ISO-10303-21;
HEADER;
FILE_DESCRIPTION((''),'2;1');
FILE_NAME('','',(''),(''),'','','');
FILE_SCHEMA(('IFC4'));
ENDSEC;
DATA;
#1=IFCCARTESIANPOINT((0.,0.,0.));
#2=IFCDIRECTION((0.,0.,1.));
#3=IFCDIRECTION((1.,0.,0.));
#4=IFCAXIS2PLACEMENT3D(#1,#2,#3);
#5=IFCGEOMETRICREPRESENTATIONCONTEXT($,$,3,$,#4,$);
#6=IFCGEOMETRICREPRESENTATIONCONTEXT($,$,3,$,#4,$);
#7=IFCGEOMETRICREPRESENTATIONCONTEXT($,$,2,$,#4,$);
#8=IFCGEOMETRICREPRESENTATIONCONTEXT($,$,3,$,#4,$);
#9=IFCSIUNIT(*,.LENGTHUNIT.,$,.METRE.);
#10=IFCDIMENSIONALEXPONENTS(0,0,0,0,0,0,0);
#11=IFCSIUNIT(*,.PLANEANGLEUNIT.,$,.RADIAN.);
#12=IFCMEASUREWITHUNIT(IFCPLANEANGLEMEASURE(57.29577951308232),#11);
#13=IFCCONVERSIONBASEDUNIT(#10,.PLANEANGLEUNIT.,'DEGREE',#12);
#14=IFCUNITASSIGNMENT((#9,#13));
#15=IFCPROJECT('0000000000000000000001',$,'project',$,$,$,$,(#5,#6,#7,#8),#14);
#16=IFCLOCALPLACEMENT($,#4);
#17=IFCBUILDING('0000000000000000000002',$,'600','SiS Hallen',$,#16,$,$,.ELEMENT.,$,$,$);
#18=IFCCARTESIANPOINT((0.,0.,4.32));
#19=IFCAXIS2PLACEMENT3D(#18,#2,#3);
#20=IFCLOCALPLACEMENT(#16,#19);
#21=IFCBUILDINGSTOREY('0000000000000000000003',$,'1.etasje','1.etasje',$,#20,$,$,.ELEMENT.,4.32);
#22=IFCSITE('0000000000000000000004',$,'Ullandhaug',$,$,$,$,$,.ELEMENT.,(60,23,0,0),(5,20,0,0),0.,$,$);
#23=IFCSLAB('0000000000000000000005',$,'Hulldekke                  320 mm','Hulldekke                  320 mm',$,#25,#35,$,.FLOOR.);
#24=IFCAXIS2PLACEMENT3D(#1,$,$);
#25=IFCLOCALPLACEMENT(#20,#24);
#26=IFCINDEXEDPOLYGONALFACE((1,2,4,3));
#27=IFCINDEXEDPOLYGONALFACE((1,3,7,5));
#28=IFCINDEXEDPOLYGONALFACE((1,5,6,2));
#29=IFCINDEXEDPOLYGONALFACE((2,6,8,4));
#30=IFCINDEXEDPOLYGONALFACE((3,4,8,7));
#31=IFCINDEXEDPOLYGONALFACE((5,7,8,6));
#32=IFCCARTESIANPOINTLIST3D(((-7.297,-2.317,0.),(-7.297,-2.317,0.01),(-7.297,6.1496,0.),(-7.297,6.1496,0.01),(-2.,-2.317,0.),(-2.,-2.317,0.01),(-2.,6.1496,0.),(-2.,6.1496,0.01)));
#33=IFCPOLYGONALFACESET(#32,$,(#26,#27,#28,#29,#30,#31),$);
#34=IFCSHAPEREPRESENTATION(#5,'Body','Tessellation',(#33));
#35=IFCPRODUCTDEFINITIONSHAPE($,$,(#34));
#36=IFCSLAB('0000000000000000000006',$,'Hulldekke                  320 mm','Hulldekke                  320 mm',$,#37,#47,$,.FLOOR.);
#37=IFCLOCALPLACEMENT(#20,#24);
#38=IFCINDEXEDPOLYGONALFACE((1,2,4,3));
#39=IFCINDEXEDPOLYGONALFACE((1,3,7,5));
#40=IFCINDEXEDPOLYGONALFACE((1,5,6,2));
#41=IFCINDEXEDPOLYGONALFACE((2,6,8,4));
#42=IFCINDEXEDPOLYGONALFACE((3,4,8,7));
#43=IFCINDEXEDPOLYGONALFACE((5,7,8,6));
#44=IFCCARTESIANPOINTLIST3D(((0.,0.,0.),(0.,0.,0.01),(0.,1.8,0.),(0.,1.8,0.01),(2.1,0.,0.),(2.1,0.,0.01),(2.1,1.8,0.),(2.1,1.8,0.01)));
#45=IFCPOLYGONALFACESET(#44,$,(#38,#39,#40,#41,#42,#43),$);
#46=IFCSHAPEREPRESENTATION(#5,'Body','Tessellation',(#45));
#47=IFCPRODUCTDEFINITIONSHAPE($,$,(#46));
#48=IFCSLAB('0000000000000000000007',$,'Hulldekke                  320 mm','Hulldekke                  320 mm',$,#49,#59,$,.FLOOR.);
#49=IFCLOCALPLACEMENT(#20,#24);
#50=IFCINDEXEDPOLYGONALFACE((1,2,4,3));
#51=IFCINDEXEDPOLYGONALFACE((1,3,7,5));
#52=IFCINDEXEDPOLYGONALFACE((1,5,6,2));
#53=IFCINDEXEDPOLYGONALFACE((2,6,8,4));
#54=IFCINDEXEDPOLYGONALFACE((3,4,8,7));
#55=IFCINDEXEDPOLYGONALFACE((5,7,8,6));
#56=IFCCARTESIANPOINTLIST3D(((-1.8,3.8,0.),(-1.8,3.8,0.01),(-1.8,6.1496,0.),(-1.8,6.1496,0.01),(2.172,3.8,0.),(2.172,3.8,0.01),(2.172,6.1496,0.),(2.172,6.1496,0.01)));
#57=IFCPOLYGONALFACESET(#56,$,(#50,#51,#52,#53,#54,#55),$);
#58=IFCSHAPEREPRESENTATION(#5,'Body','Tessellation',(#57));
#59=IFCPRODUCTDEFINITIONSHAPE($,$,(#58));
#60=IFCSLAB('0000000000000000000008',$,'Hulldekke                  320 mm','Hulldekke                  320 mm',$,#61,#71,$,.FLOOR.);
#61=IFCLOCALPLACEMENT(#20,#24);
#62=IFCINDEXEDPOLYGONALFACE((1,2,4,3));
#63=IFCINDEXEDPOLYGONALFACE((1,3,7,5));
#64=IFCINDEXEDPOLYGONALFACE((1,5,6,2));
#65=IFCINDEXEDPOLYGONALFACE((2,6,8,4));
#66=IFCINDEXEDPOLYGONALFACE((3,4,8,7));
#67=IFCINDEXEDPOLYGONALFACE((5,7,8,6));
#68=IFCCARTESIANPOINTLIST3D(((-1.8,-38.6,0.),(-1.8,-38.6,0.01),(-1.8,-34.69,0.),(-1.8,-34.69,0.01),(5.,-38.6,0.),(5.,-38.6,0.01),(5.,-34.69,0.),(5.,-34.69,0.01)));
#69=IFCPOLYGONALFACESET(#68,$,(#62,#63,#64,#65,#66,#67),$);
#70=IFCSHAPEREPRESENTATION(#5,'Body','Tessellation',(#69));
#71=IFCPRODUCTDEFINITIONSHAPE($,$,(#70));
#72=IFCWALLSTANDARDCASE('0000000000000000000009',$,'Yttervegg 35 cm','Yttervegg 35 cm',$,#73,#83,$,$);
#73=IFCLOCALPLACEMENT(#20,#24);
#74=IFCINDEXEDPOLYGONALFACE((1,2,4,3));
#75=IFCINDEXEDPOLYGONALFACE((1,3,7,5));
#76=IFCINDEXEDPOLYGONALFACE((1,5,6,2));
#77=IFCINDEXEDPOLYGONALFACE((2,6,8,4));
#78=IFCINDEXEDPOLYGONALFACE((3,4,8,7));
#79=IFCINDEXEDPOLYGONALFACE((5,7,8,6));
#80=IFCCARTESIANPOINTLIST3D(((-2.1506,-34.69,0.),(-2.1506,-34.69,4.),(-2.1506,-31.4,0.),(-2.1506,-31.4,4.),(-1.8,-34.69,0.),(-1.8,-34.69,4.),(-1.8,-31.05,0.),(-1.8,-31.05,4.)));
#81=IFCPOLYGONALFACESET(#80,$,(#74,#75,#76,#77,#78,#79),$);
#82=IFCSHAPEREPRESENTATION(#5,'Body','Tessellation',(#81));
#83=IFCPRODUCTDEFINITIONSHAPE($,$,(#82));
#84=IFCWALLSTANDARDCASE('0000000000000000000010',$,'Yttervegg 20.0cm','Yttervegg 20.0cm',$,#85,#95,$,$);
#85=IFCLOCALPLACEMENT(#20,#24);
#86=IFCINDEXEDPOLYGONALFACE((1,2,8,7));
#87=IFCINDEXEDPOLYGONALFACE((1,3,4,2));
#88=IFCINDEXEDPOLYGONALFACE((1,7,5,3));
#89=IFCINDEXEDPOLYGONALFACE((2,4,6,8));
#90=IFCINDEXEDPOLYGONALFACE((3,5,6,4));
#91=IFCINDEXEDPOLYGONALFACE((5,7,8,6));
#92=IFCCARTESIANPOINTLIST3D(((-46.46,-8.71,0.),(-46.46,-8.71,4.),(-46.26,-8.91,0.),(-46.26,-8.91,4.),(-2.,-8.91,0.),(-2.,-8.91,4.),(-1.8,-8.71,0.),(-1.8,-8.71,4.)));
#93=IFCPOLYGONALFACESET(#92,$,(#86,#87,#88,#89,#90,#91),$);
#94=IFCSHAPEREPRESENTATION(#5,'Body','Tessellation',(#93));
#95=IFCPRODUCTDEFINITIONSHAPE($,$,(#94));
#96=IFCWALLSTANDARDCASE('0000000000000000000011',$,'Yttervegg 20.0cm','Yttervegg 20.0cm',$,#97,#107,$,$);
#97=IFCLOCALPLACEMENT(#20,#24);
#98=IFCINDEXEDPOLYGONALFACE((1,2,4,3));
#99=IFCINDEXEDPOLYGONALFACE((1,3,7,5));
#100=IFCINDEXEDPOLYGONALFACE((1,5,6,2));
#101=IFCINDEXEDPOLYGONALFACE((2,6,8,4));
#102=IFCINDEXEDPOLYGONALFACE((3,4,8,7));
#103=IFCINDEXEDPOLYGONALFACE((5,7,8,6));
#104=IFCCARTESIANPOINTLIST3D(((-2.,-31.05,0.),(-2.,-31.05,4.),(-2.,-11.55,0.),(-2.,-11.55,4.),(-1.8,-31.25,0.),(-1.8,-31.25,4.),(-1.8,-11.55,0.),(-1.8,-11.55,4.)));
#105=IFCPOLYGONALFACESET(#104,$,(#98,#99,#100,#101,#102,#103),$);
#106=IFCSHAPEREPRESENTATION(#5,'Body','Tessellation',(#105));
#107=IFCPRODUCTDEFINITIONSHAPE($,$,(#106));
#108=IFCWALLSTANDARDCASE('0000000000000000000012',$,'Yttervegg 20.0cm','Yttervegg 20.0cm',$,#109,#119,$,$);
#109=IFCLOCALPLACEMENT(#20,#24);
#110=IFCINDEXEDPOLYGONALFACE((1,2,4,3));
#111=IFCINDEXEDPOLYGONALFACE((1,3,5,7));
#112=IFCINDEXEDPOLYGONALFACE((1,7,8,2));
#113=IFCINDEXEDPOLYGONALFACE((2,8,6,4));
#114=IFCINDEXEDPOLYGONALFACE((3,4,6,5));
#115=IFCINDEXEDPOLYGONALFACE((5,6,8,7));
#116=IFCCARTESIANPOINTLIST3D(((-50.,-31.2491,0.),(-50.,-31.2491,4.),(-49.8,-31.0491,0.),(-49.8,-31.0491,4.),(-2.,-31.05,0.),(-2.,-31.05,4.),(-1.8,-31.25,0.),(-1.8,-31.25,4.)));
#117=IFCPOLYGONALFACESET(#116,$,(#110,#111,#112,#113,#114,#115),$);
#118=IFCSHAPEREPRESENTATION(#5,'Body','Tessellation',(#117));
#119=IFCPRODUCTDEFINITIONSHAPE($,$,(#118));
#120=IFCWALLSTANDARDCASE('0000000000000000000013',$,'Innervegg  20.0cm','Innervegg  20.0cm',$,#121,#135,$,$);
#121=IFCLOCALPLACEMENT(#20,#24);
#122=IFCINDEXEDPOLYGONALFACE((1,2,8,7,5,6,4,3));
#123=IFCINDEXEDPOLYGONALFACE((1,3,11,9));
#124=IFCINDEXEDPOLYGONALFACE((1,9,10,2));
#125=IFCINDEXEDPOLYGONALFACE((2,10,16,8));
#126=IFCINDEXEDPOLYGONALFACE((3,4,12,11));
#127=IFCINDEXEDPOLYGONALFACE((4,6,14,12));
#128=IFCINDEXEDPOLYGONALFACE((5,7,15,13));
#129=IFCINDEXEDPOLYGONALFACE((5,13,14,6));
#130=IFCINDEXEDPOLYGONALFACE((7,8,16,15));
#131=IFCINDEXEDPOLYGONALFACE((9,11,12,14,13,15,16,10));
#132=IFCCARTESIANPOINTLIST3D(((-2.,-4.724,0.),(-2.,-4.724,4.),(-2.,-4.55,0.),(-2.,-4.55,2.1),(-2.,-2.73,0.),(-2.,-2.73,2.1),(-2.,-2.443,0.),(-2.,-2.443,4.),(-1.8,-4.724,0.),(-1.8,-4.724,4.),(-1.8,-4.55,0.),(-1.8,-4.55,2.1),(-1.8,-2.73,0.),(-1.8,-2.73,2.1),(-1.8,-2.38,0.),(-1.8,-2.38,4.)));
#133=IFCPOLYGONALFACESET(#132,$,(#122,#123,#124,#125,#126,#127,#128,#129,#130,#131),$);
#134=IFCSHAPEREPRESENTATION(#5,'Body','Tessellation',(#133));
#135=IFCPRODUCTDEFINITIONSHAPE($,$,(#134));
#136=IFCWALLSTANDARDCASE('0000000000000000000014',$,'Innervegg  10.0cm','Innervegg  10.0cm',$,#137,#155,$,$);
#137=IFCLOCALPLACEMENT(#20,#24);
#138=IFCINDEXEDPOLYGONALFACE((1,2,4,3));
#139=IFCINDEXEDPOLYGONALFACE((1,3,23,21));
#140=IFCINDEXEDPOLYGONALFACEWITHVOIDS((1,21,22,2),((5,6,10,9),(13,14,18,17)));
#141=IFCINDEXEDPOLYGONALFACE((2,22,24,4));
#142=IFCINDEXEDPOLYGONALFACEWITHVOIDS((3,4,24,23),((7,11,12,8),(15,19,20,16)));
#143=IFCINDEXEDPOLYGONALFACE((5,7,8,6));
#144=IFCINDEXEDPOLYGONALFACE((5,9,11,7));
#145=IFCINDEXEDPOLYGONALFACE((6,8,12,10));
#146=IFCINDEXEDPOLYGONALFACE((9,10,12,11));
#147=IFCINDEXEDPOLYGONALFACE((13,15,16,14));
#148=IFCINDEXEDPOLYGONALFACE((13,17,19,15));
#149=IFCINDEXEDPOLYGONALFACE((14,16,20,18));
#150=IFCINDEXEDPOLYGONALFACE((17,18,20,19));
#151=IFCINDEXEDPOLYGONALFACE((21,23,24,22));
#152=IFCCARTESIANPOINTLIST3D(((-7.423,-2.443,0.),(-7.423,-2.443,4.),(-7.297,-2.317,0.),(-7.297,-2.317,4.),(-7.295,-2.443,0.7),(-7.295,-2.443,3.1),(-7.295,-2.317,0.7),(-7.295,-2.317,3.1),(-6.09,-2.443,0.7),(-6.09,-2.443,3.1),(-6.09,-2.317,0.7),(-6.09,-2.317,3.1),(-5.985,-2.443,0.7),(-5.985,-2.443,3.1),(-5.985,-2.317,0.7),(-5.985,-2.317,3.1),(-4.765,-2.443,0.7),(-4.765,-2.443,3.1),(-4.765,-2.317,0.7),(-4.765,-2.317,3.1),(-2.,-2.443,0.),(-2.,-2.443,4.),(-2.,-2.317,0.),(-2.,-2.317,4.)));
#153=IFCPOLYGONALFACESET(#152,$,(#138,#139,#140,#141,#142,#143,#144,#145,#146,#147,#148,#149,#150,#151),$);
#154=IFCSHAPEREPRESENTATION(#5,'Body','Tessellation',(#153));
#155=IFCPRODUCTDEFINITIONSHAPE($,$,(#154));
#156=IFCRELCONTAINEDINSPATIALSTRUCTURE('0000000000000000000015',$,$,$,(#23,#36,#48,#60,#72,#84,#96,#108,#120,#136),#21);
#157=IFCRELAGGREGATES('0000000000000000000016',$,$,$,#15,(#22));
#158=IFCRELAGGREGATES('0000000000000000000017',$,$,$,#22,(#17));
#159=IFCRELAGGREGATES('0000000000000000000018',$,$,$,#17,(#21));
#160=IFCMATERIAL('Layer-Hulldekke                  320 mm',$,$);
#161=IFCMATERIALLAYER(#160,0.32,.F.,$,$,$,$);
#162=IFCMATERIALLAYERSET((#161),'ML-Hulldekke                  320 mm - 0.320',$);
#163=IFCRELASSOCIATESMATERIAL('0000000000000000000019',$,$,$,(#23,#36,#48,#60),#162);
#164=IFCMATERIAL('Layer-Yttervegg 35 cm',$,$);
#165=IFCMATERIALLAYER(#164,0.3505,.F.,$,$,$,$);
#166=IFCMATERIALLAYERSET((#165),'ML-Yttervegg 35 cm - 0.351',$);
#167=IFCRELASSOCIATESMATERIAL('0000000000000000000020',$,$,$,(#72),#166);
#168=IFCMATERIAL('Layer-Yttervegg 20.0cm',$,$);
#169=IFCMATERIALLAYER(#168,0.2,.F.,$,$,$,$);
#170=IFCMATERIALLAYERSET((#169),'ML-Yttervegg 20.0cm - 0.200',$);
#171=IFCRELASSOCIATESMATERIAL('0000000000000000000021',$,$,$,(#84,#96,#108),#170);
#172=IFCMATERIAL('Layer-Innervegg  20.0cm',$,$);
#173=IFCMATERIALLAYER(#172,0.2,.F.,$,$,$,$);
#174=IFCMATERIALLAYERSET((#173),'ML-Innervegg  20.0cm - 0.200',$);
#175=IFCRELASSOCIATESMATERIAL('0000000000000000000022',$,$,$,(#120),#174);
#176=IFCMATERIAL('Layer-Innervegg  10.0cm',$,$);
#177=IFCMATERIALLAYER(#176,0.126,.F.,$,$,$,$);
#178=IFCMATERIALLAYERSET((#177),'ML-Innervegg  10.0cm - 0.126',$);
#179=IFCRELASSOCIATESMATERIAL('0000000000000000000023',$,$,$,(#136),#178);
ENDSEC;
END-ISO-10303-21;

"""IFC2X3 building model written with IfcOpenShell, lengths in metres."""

from ifc_helpers import new_model, entity, si_unit, converted_unit, frame, origin_with_axes, place, context, project, spatial, polyline, outline, extrude, material, layer, layer_set, layer_usage, element, save


model = new_model("IFC2X3")

# Units and contexts
context_of_model_1 = context(None, 3, world=origin_with_axes())
context_of_model_2 = context(None, 3, world=origin_with_axes())
context_of_model_3 = context(None, 2, world=origin_with_axes())
context_of_model_4 = context(None, 3, world=origin_with_axes())
ifc_project = project(units=[si_unit("LENGTHUNIT", "METRE"), converted_unit("PLANEANGLEUNIT", "DEGREE", entity("IfcPlaneAngleMeasure", 57.29577951308232), si_unit("PLANEANGLEUNIT", "RADIAN"), dimensions=[0, 0, 0, 0, 0, 0, 0])], contexts=[context_of_model_1, context_of_model_2, context_of_model_3, context_of_model_4])

# Site, building, storey
site = spatial("IfcSite", under=ifc_project, Name="Ullandhaug", CompositionType="ELEMENT", RefLatitude=(60, 23, 0, 0), RefLongitude=(5, 20, 0, 0), RefElevation=0.0)
building_placement = place(None, origin_with_axes())
building = spatial("IfcBuilding", under=site, at=building_placement, Name="600", Description="SiS Hallen", CompositionType="ELEMENT")
storey_placement = place(building_placement, frame((0.0, 0.0, 4.32), z_axis=(0.0, 0.0, 1.0), x_axis=(1.0, 0.0, 0.0)))
storey = spatial("IfcBuildingStorey", under=building, at=storey_placement, Name="1.etasje", Description="1.etasje", CompositionType="ELEMENT", Elevation=4.32)

# Slabs
ifc_material_1 = material(Name="Layer-Hulldekke                  320 mm")
ifc_layer_1 = layer(ifc_material_1, 0.32, ventilated=False)
ifc_layer_set_1 = layer_set([ifc_layer_1], Name="ML-Hulldekke                  320 mm - 0.320")
ifc_layer_usage_1 = layer_usage(ifc_layer_set_1, "AXIS2", "POSITIVE", 0.0)
slab_1_placement = place(storey_placement, frame((-7.297, -2.317, 0.0), z_axis=(0.0, 0.0, 1.0), x_axis=(1.0, 0.0, 0.0)))
element("IfcSlab", 1, at=slab_1_placement, inside=storey, material=ifc_layer_usage_1, Name="Hulldekke                  320 mm", Description="Hulldekke                  320 mm", PredefinedType="FLOOR", context=context_of_model_1, shape_type="SweptSolid", body=[
    extrude(outline(polyline([(0.0, 0.0), (5.297, 0.0), (5.297, 8.4666), (0.0, 8.4666), (0.0, 0.0)])), origin_with_axes(), (0.0, 0.0, 1.0), 0.01),
])
slab_2_placement = place(storey_placement, origin_with_axes())
element("IfcSlab", 2, at=slab_2_placement, inside=storey, material=ifc_layer_usage_1, Name="Hulldekke                  320 mm", Description="Hulldekke                  320 mm", PredefinedType="FLOOR", context=context_of_model_1, shape_type="SweptSolid", body=[
    extrude(outline(polyline([(0.0, 0.0), (2.1, 0.0), (2.1, 1.8), (0.0, 1.8), (0.0, 0.0)])), origin_with_axes(), (0.0, 0.0, 1.0), 0.01),
])
slab_3_placement = place(storey_placement, frame((-1.8, 3.8, 0.0), z_axis=(0.0, 0.0, 1.0), x_axis=(1.0, 0.0, 0.0)))
element("IfcSlab", 3, at=slab_3_placement, inside=storey, material=ifc_layer_usage_1, Name="Hulldekke                  320 mm", Description="Hulldekke                  320 mm", PredefinedType="FLOOR", context=context_of_model_1, shape_type="SweptSolid", body=[
    extrude(outline(polyline([(0.0, 0.0), (3.972, 0.0), (3.972, 2.3496), (0.0, 2.3496), (0.0, 0.0)])), origin_with_axes(), (0.0, 0.0, 1.0), 0.01),
])
slab_4_placement = place(storey_placement, frame((-1.8, -38.6, 0.0), z_axis=(0.0, 0.0, 1.0), x_axis=(1.0, 0.0, 0.0)))
element("IfcSlab", 4, at=slab_4_placement, inside=storey, material=ifc_layer_usage_1, Name="Hulldekke                  320 mm", Description="Hulldekke                  320 mm", PredefinedType="FLOOR", context=context_of_model_1, shape_type="SweptSolid", body=[
    extrude(outline(polyline([(0.0, 0.0), (6.8, 0.0), (6.8, 3.91), (0.0, 3.91), (0.0, 0.0)])), origin_with_axes(), (0.0, 0.0, 1.0), 0.01),
])

# Walls
ifc_material_2 = material(Name="Layer-Yttervegg 35 cm")
ifc_layer_2 = layer(ifc_material_2, 0.3505, ventilated=False)
ifc_layer_set_2 = layer_set([ifc_layer_2], Name="ML-Yttervegg 35 cm - 0.351")
ifc_layer_usage_2 = layer_usage(ifc_layer_set_2, "AXIS2", "POSITIVE", 0.0)
wall_1_placement = place(storey_placement, frame((-2.1506, -31.4, 0.0), z_axis=(0.0, 0.0, 1.0), x_axis=(0.0, -1.0, 0.0)))
element("IfcWallStandardCase", 5, at=wall_1_placement, inside=storey, material=ifc_layer_usage_2, Name="Yttervegg 35 cm", Description="Yttervegg 35 cm", context=context_of_model_1, shape_type="SweptSolid", body=[
    extrude(outline(polyline([(0.0, 0.0), (3.29, 0.0), (3.29, 0.3506), (-0.35, 0.3506), (0.0, 0.0)])), frame((0.0, 0.0, 0.0), z_axis=(0.0, 0.0, 1.0), x_axis=(1.0, 0.0, 0.0)), (0.0, 0.0, 1.0), 4.0),
])
ifc_material_3 = material(Name="Layer-Yttervegg 20.0cm")
ifc_layer_3 = layer(ifc_material_3, 0.2, ventilated=False)
ifc_layer_set_3 = layer_set([ifc_layer_3], Name="ML-Yttervegg 20.0cm - 0.200")
ifc_layer_usage_3 = layer_usage(ifc_layer_set_3, "AXIS2", "POSITIVE", 0.0)
wall_2_placement = place(storey_placement, frame((-46.26, -8.91, 0.0), z_axis=(0.0, 0.0, 1.0), x_axis=(1.0, 0.0, 0.0)))
element("IfcWallStandardCase", 6, at=wall_2_placement, inside=storey, material=ifc_layer_usage_3, Name="Yttervegg 20.0cm", Description="Yttervegg 20.0cm", context=context_of_model_1, shape_type="SweptSolid", body=[
    extrude(outline(polyline([(0.0, 0.0), (44.26, 0.0), (44.46, 0.2), (-0.2, 0.2), (0.0, 0.0)])), origin_with_axes(), (0.0, 0.0, 1.0), 4.0),
])
wall_3_placement = place(storey_placement, frame((-2.0, -11.55, 0.0), z_axis=(0.0, 0.0, 1.0), x_axis=(0.0, -1.0, 0.0)))
element("IfcWallStandardCase", 7, at=wall_3_placement, inside=storey, material=ifc_layer_usage_3, Name="Yttervegg 20.0cm", Description="Yttervegg 20.0cm", context=context_of_model_1, shape_type="SweptSolid", body=[
    extrude(outline(polyline([(0.0, 0.0), (19.5, 0.0), (19.7, 0.2), (0.0, 0.2), (0.0, 0.0)])), frame((0.0, 0.0, 0.0), z_axis=(0.0, 0.0, 1.0), x_axis=(1.0, 0.0, 0.0)), (0.0, 0.0, 1.0), 4.0),
])
wall_4_placement = place(storey_placement, frame((-2.0, -31.05, 0.0), z_axis=(0.0, 0.0, 1.0), x_axis=(-1.0, 0.000019, 0.0)))
element("IfcWallStandardCase", 8, at=wall_4_placement, inside=storey, material=ifc_layer_usage_3, Name="Yttervegg 20.0cm", Description="Yttervegg 20.0cm", context=context_of_model_1, shape_type="SweptSolid", body=[
    extrude(outline(polyline([(0.0, 0.0), (47.8, 0.0), (48.0, 0.2), (-0.2, 0.2), (0.0, 0.0)])), frame((0.0, 0.0, 0.0), z_axis=(0.0, 0.0, 1.0), x_axis=(1.0, 0.0, 0.0)), (0.0, 0.0, 1.0), 4.0),
])

# Wall, opening
ifc_material_4 = material(Name="Layer-Innervegg  20.0cm")
ifc_layer_4 = layer(ifc_material_4, 0.2, ventilated=False)
ifc_layer_set_4 = layer_set([ifc_layer_4], Name="ML-Innervegg  20.0cm - 0.200")
ifc_layer_usage_4 = layer_usage(ifc_layer_set_4, "AXIS2", "POSITIVE", 0.0)
wall_5_placement = place(storey_placement, frame((-1.8, -4.724, 0.0), z_axis=(0.0, 0.0, 1.0), x_axis=(0.0, 1.0, 0.0)))
wall_5 = element("IfcWallStandardCase", 9, at=wall_5_placement, inside=storey, material=ifc_layer_usage_4, Name="Innervegg  20.0cm", Description="Innervegg  20.0cm", context=context_of_model_1, shape_type="SweptSolid", body=[
    extrude(outline(polyline([(0.0, 0.0), (2.344, 0.0), (2.281, 0.2), (0.0, 0.2), (0.0, 0.0)])), frame((0.0, 0.0, 0.0), z_axis=(0.0, 0.0, 1.0), x_axis=(1.0, 0.0, 0.0)), (0.0, 0.0, 1.0), 4.0),
])
opening_1_placement = place(wall_5_placement, frame((0.174, 0.2, 0.0), z_axis=(0.0, 0.0, 1.0), x_axis=(1.0, 0.0, 0.0)))
element("IfcOpeningElement", 10, at=opening_1_placement, cuts=wall_5, context=context_of_model_1, shape_type="SweptSolid", body=[
    extrude(outline(polyline([(0.0, 0.0), (2.1, 0.0), (2.1, 1.82), (0.0, 1.82), (0.0, 0.0)])), frame((0.0, 0.0, 0.0), z_axis=(0.0, 1.0, 0.0), x_axis=(0.0, 0.0, 1.0)), (0.0, 0.0, -1.0), 0.2),
])

# Wall, openings
ifc_material_5 = material(Name="Layer-Innervegg  10.0cm")
ifc_layer_5 = layer(ifc_material_5, 0.126, ventilated=False)
ifc_layer_set_5 = layer_set([ifc_layer_5], Name="ML-Innervegg  10.0cm - 0.126")
ifc_layer_usage_5 = layer_usage(ifc_layer_set_5, "AXIS2", "POSITIVE", 0.0)
wall_6_placement = place(storey_placement, frame((-2.0, -2.317, 0.0), z_axis=(0.0, 0.0, 1.0), x_axis=(-1.0, 0.0, 0.0)))
wall_6 = element("IfcWallStandardCase", 11, at=wall_6_placement, inside=storey, material=ifc_layer_usage_5, Name="Innervegg  10.0cm", Description="Innervegg  10.0cm", context=context_of_model_1, shape_type="SweptSolid", body=[
    extrude(outline(polyline([(0.0, 0.0), (5.297, 0.0), (5.423, 0.126), (0.0, 0.126), (0.0, 0.0)])), frame((0.0, 0.0, 0.0), z_axis=(0.0, 0.0, 1.0), x_axis=(1.0, 0.0, 0.0)), (0.0, 0.0, 1.0), 4.0),
])
opening_2_placement = place(wall_6_placement, frame((4.09, 0.126, 0.7), z_axis=(0.0, 0.0, 1.0), x_axis=(1.0, 0.0, 0.0)))
element("IfcOpeningElement", 12, at=opening_2_placement, cuts=wall_6, context=context_of_model_1, shape_type="SweptSolid", body=[
    extrude(outline(polyline([(0.0, 0.0), (2.4, 0.0), (2.4, 1.205), (0.0, 1.205), (0.0, 0.0)])), frame((0.0, 0.0, 0.0), z_axis=(0.0, 1.0, 0.0), x_axis=(0.0, 0.0, 1.0)), (0.0, 0.0, -1.0), 0.126),
])
opening_3_placement = place(wall_6_placement, frame((2.765, 0.126, 0.7), z_axis=(0.0, 0.0, 1.0), x_axis=(1.0, 0.0, 0.0)))
element("IfcOpeningElement", 13, at=opening_3_placement, cuts=wall_6, context=context_of_model_1, shape_type="SweptSolid", body=[
    extrude(outline(polyline([(0.0, 0.0), (2.4, 0.0), (2.4, 1.22), (0.0, 1.22), (0.0, 0.0)])), frame((0.0, 0.0, 0.0), z_axis=(0.0, 1.0, 0.0), x_axis=(0.0, 0.0, 1.0)), (0.0, 0.0, -1.0), 0.126),
])

save(model, "model.ifc")
